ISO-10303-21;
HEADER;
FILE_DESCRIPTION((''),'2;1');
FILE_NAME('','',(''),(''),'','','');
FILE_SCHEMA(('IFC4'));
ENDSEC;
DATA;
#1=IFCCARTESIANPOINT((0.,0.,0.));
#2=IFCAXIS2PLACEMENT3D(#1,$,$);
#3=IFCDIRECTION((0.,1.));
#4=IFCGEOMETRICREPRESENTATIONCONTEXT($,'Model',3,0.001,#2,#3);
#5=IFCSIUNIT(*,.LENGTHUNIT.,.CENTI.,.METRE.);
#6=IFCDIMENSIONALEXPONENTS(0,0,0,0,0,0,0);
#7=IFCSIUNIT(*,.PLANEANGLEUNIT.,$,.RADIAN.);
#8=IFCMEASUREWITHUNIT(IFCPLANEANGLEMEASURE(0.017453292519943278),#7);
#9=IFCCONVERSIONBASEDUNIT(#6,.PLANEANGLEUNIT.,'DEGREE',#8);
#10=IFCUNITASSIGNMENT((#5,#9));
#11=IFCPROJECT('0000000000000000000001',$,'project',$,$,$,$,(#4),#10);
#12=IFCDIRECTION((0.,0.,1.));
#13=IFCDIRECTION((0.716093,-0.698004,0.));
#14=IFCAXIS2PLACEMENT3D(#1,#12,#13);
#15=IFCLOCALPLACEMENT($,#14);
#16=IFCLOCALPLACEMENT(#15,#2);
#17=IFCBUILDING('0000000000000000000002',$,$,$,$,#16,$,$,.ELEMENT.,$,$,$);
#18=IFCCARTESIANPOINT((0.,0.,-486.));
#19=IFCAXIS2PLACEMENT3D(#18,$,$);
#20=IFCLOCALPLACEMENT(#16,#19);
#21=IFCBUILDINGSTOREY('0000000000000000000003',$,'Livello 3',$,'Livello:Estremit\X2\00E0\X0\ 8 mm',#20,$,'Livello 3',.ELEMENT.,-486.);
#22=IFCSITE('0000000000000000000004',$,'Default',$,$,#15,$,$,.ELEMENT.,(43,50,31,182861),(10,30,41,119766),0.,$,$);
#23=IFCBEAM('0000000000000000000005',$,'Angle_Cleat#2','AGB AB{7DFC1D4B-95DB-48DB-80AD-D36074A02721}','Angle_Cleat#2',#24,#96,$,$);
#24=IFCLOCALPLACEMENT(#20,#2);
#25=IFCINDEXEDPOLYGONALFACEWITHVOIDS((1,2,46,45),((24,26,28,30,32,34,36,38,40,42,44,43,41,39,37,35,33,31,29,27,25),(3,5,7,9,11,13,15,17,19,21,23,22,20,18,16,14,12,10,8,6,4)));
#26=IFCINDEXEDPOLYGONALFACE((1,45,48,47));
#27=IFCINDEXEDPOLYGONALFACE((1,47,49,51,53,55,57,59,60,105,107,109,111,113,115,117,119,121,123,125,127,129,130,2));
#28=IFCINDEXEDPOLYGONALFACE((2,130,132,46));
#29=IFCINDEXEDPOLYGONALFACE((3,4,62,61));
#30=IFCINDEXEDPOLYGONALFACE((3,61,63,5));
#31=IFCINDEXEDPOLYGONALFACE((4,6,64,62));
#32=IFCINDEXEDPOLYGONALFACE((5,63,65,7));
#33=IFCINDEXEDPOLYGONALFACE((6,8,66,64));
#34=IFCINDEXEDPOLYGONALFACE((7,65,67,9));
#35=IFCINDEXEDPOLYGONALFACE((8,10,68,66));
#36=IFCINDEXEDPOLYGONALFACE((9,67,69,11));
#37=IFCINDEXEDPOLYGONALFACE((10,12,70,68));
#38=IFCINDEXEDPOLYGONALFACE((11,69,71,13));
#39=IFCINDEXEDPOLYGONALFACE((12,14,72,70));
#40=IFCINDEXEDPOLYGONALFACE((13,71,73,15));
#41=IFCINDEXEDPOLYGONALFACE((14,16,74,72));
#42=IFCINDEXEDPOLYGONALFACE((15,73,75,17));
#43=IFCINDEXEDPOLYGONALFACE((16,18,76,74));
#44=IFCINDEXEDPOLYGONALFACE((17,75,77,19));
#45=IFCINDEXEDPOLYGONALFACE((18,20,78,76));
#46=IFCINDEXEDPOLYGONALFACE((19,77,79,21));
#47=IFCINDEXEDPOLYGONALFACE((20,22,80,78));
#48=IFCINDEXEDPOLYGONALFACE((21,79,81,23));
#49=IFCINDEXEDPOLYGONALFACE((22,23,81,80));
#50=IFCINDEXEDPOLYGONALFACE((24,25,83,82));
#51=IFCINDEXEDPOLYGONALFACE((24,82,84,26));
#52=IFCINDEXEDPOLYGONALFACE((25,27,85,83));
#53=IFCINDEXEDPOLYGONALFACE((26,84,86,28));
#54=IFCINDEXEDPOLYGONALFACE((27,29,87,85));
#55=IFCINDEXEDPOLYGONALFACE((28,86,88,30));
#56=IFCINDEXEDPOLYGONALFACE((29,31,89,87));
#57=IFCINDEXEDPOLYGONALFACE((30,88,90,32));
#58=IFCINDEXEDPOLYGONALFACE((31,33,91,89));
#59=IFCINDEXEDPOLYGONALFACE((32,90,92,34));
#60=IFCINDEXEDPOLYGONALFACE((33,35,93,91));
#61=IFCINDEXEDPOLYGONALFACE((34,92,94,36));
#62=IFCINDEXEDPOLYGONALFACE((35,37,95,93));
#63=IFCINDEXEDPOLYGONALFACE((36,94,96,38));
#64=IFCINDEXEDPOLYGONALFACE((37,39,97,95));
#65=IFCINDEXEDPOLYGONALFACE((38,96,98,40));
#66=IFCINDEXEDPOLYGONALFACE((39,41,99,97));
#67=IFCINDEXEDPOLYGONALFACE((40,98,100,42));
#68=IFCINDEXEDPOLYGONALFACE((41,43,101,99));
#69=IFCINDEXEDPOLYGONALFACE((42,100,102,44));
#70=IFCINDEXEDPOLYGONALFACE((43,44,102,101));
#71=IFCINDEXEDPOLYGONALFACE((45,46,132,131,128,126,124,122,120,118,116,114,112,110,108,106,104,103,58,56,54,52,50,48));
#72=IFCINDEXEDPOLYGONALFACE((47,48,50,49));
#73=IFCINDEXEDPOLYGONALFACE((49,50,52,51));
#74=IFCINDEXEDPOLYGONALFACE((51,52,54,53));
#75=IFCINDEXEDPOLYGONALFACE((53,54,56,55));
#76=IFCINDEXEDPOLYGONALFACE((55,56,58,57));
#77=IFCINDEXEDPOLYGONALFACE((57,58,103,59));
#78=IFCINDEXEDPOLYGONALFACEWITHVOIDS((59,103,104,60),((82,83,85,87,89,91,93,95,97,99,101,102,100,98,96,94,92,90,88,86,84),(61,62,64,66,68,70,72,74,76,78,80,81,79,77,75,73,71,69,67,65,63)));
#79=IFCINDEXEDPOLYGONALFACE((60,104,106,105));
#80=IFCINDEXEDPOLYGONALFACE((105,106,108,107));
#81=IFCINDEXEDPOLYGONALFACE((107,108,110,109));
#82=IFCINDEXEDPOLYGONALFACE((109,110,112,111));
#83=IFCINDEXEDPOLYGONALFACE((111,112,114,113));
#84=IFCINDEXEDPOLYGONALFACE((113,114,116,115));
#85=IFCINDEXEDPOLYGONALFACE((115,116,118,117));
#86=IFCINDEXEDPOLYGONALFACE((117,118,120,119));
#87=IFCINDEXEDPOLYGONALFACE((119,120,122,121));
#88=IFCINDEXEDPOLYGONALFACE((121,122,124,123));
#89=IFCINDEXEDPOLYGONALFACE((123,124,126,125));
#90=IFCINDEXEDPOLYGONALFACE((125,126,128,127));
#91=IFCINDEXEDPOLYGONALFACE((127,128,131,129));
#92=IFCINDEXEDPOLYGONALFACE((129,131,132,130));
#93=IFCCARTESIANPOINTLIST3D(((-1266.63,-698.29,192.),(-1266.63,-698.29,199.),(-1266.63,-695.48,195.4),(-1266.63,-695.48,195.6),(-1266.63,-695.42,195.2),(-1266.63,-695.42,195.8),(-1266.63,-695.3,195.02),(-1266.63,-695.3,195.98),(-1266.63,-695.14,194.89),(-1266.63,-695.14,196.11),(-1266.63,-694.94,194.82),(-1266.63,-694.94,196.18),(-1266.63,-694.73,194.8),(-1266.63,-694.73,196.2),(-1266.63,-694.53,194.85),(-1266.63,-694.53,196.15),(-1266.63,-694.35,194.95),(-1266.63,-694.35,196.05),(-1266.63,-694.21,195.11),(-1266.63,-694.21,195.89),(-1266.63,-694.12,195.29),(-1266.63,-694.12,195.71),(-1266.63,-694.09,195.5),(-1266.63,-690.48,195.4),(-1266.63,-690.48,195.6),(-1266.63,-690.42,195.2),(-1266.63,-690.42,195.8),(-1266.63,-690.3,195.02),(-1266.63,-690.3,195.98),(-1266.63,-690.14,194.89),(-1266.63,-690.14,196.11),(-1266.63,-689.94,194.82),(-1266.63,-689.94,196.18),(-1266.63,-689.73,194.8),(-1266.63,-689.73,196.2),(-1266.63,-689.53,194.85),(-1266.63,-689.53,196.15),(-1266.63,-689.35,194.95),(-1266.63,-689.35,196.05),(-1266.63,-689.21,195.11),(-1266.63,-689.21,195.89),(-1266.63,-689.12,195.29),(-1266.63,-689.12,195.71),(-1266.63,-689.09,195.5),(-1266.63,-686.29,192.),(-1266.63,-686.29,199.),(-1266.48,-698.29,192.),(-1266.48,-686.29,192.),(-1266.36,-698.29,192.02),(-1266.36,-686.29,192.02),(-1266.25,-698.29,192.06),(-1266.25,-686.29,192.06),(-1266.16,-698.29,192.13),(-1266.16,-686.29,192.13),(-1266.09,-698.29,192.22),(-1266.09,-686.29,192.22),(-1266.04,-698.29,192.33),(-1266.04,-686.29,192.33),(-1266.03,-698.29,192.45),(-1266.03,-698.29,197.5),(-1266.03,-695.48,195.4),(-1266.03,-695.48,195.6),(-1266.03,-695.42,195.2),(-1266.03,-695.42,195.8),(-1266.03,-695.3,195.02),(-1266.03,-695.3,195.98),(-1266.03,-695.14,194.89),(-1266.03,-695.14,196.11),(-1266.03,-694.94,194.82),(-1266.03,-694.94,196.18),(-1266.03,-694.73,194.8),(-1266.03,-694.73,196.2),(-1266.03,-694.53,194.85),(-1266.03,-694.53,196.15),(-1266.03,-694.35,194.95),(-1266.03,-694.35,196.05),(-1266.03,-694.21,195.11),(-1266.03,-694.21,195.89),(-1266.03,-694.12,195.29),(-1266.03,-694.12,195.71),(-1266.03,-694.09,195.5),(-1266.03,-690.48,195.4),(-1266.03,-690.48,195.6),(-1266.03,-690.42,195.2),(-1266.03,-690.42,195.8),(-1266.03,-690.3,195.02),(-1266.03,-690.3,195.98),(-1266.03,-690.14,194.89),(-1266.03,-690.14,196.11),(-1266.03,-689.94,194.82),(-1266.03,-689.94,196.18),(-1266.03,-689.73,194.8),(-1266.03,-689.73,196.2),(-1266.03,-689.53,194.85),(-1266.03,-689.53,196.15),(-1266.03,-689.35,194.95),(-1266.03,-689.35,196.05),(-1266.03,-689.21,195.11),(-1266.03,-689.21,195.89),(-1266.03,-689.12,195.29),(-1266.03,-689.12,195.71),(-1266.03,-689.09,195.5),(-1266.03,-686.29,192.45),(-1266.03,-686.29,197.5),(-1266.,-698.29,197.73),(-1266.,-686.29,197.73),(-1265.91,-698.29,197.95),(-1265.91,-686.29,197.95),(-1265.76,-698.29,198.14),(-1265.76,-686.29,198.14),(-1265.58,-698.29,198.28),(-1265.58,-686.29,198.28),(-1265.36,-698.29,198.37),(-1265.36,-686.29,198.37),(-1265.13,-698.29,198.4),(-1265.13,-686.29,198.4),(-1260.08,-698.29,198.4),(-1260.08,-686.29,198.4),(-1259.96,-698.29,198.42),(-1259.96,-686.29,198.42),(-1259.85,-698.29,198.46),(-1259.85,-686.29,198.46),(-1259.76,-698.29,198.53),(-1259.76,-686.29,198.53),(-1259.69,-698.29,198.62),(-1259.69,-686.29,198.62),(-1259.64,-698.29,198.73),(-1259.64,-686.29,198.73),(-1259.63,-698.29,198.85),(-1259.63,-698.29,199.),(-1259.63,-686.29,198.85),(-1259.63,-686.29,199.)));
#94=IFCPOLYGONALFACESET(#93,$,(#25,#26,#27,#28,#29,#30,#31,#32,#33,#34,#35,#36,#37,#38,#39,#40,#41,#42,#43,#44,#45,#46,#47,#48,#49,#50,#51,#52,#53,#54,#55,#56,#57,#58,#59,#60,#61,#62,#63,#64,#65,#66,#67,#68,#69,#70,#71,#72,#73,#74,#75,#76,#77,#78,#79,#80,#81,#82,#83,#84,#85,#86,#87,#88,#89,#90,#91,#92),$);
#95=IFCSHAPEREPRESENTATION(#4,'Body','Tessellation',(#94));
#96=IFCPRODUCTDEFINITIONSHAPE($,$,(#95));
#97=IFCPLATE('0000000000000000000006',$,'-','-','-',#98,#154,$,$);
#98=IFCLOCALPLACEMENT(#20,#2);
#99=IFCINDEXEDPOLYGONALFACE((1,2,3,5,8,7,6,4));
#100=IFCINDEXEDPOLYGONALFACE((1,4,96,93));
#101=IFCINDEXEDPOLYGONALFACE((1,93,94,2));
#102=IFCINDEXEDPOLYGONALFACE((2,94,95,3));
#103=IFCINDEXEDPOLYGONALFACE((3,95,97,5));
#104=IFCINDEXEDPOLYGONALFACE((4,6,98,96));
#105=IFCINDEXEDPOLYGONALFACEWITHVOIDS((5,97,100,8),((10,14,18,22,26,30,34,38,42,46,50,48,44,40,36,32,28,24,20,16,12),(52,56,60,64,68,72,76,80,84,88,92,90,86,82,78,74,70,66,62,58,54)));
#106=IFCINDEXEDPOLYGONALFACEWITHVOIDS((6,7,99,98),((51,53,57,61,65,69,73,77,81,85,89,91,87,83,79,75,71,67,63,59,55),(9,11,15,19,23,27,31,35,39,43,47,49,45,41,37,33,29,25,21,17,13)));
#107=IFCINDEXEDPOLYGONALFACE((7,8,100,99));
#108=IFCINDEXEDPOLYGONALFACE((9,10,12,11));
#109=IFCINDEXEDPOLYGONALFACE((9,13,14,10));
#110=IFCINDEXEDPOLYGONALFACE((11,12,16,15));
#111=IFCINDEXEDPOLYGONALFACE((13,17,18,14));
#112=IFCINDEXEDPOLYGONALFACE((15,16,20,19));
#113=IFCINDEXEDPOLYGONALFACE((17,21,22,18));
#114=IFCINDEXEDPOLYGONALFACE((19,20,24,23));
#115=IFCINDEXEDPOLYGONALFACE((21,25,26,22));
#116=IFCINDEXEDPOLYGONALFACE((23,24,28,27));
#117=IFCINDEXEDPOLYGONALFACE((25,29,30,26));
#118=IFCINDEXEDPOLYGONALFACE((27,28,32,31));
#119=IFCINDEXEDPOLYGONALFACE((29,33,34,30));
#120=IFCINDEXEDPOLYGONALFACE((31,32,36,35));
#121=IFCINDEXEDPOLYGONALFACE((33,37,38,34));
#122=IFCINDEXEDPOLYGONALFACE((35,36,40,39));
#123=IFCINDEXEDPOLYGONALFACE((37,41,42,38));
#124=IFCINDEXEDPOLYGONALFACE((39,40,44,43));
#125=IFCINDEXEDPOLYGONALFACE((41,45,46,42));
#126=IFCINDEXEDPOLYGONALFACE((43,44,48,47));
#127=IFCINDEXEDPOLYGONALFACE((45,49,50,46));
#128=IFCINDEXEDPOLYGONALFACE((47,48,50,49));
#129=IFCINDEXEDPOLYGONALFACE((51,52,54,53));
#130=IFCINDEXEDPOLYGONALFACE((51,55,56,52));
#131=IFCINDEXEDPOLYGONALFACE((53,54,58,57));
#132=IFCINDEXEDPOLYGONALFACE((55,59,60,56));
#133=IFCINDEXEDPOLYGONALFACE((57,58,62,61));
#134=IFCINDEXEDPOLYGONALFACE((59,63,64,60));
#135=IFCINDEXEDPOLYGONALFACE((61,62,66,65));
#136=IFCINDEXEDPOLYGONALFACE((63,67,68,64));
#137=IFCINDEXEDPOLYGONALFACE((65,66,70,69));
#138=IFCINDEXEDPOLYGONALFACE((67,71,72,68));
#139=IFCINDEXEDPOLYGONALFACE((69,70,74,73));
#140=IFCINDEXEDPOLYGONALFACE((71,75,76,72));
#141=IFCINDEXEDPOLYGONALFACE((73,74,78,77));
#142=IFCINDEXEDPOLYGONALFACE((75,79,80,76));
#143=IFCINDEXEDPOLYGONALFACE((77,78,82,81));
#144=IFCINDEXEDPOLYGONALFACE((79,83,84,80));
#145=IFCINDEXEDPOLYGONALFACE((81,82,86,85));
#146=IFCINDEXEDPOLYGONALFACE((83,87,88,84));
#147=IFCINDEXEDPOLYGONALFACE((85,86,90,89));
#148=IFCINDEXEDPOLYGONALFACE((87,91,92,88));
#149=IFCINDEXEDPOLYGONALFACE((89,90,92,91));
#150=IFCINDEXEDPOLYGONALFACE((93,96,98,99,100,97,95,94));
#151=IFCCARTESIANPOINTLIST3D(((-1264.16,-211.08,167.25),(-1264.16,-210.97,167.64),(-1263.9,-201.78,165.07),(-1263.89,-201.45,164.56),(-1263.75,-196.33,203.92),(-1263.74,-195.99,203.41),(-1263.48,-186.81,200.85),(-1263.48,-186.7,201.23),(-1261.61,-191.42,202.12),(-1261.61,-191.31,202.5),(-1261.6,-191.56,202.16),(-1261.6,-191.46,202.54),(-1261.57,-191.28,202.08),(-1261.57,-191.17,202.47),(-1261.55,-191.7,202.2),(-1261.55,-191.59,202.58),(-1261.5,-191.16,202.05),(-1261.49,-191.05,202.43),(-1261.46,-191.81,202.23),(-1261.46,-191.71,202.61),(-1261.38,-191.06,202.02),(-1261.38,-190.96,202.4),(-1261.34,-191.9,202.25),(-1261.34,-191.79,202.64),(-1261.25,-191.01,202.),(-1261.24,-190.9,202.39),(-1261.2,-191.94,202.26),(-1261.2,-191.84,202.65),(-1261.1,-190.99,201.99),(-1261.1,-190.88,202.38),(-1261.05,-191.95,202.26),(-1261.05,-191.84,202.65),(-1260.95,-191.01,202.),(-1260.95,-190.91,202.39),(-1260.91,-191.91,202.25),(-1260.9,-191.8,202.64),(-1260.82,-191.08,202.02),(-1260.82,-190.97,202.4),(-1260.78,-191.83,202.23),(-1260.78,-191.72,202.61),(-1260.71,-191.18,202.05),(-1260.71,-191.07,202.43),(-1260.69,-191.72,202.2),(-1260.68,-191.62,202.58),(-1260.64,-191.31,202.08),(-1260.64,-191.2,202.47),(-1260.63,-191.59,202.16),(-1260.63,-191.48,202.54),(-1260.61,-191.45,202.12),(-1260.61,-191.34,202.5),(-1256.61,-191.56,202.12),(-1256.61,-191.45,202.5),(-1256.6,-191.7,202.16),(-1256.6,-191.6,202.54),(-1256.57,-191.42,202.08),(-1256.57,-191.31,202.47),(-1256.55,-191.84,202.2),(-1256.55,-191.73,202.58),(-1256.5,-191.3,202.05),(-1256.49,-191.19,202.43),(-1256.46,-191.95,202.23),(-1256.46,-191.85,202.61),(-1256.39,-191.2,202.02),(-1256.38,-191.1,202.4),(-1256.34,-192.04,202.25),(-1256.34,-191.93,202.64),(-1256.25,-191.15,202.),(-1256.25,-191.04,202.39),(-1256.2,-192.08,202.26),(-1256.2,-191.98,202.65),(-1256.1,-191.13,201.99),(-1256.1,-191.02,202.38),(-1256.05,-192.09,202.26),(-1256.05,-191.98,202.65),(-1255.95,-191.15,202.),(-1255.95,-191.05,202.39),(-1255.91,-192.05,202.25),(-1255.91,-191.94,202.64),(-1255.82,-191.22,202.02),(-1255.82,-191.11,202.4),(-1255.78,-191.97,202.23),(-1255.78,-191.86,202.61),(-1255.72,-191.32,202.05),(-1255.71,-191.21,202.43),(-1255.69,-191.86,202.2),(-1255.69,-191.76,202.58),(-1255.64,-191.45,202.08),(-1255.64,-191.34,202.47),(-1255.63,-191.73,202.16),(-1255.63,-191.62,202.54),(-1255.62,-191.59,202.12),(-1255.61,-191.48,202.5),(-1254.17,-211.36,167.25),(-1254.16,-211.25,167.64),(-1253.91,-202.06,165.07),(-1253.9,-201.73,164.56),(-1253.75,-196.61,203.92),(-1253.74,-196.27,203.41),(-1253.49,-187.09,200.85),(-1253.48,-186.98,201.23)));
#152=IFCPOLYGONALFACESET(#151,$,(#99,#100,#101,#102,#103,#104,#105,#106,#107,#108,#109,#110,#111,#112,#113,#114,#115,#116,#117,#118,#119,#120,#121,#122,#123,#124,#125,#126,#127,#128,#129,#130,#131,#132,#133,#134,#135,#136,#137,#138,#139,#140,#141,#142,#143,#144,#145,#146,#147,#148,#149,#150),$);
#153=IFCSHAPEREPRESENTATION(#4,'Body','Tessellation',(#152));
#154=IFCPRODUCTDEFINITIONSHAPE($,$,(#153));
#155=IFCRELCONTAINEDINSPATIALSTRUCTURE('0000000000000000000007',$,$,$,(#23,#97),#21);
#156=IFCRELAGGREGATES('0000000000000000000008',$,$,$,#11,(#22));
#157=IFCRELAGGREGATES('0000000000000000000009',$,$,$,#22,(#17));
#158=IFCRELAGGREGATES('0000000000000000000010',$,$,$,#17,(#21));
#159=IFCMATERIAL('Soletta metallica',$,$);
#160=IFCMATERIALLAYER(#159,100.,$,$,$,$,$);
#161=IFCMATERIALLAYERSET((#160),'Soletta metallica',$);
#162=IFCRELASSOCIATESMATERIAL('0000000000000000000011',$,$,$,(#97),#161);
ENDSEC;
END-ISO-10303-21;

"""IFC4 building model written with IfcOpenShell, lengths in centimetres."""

from ifc_helpers import new_model, entity, si_unit, converted_unit, direction, frame, frame_2d, origin, origin_with_axes, place, context, project, spatial, polyline, circle, l_section, outline, extrude, material, layer, layer_set, element, save


model = new_model("IFC4")

# Units and contexts
model_context = context("Model", 3, precision=0.001, world=origin(), true_north=direction((0.0, 1.0)))
ifc_project = project(units=[si_unit("LENGTHUNIT", "METRE", prefix="CENTI"), converted_unit("PLANEANGLEUNIT", "DEGREE", entity("IfcPlaneAngleMeasure", 0.017453292519943278), si_unit("PLANEANGLEUNIT", "RADIAN"), dimensions=[0, 0, 0, 0, 0, 0, 0])], contexts=[model_context])

# Site, building, storey
site_placement = place(None, frame((0.0, 0.0, 0.0), z_axis=(0.0, 0.0, 1.0), x_axis=(0.716093, -0.698004, 0.0)))
site = spatial("IfcSite", under=ifc_project, at=site_placement, Name="Default", CompositionType="ELEMENT", RefLatitude=(43, 50, 31, 182861), RefLongitude=(10, 30, 41, 119766), RefElevation=0.0)
building_placement = place(site_placement, origin())
building = spatial("IfcBuilding", under=site, at=building_placement, CompositionType="ELEMENT")
storey_placement = place(building_placement, frame((0.0, 0.0, -486.0)))
storey = spatial("IfcBuildingStorey", under=building, at=storey_placement, Name="Livello 3", ObjectType="Livello:Estremità 8 mm", LongName="Livello 3", CompositionType="ELEMENT", Elevation=-486.0)

# Beam, openings
beam_1_placement = place(storey_placement, frame((-1264.7, -686.29, 197.07), z_axis=(0.0, 1.0, 0.0), x_axis=(1.0, 0.0, 0.0)))
beam_1 = element("IfcBeam", 1, at=beam_1_placement, inside=storey, Name="Angle_Cleat#2", Description="AGB AB{7DFC1D4B-95DB-48DB-80AD-D36074A02721}", ObjectType="Angle_Cleat#2", context=model_context, shape_type="SweptSolid", body=[
    extrude(l_section(Depth=7.0, Width=7.0, Thickness=0.6, FilletRadius=0.9, EdgeRadius=0.45, at=frame_2d((1.57, 1.57))), origin(), (0.0, 0.0, -1.0), 12.0),
])
opening_1_placement = place(beam_1_placement, frame((-1.98, 1.57, -6.0), z_axis=(1.0, 0.0, 0.0), x_axis=(0.0, 0.0, 1.0)))
element("IfcOpeningElement", 2, at=opening_1_placement, cuts=beam_1, ObjectType="Opening", context=model_context, shape_type="SweptSolid", body=[
    extrude(circle(Radius=0.7, at=frame_2d((2.5, 0.0), x_axis=(1.0, 0.0))), origin(), (0.0, 0.0, 1.0), 0.7),
])
opening_2_placement = place(beam_1_placement, frame((-1.98, 1.57, -6.0), z_axis=(1.0, 0.0, 0.0), x_axis=(0.0, 0.0, 1.0)))
element("IfcOpeningElement", 3, at=opening_2_placement, cuts=beam_1, ObjectType="Opening", context=model_context, shape_type="SweptSolid", body=[
    extrude(circle(Radius=0.7, at=frame_2d((-2.5, 0.0), x_axis=(1.0, 0.0))), origin(), (0.0, 0.0, 1.0), 0.7),
])

# Plate, openings
ifc_material_1 = material(Name="Soletta metallica")
ifc_layer_1 = layer(ifc_material_1, 100.0)
ifc_layer_set_1 = layer_set([ifc_layer_1], Name="Soletta metallica")
plate_1_placement = place(storey_placement, frame((-1253.44, -185.55, 200.87), z_axis=(-0.999608, 0.02798, 0.0), x_axis=(-0.02798, -0.999608, 0.0)))
plate_1 = element("IfcPlate", 4, at=plate_1_placement, inside=storey, material=ifc_layer_set_1, Name="-", Description="-", ObjectType="-", context=model_context, shape_type="SweptSolid", body=[
    extrude(outline(polyline([(1.54, -0.03), (10.73, 2.54), (16.19, -36.31), (25.82, -33.62), (25.71, -33.24), (16.52, -35.8), (11.06, 3.05), (1.43, 0.36), (1.54, -0.03)])), origin_with_axes(), (0.0, 0.0, 1.0), 10.0),
])
opening_3_placement = place(plate_1_placement, frame((5.78, 2.51, 3.0), z_axis=(-0.268612, 0.963248, 0.0), x_axis=(-0.963248, -0.268612, 0.0)))
element("IfcOpeningElement", 5, at=opening_3_placement, cuts=plate_1, ObjectType="Opening", context=model_context, shape_type="SweptSolid", body=[
    extrude(circle(Radius=0.5, at=frame_2d((0.0, -0.5), x_axis=(1.0, 0.0))), origin(), (0.0, 0.0, -1.0), 1.35),
])
opening_4_placement = place(plate_1_placement, frame((5.78, 2.51, 8.0), z_axis=(-0.268612, 0.963248, 0.0), x_axis=(-0.963248, -0.268612, 0.0)))
element("IfcOpeningElement", 6, at=opening_4_placement, cuts=plate_1, ObjectType="Opening", context=model_context, shape_type="SweptSolid", body=[
    extrude(circle(Radius=0.5, at=frame_2d((0.0, -0.5), x_axis=(1.0, 0.0))), origin(), (0.0, 0.0, -1.0), 1.35),
])

save(model, "model.ifc")
